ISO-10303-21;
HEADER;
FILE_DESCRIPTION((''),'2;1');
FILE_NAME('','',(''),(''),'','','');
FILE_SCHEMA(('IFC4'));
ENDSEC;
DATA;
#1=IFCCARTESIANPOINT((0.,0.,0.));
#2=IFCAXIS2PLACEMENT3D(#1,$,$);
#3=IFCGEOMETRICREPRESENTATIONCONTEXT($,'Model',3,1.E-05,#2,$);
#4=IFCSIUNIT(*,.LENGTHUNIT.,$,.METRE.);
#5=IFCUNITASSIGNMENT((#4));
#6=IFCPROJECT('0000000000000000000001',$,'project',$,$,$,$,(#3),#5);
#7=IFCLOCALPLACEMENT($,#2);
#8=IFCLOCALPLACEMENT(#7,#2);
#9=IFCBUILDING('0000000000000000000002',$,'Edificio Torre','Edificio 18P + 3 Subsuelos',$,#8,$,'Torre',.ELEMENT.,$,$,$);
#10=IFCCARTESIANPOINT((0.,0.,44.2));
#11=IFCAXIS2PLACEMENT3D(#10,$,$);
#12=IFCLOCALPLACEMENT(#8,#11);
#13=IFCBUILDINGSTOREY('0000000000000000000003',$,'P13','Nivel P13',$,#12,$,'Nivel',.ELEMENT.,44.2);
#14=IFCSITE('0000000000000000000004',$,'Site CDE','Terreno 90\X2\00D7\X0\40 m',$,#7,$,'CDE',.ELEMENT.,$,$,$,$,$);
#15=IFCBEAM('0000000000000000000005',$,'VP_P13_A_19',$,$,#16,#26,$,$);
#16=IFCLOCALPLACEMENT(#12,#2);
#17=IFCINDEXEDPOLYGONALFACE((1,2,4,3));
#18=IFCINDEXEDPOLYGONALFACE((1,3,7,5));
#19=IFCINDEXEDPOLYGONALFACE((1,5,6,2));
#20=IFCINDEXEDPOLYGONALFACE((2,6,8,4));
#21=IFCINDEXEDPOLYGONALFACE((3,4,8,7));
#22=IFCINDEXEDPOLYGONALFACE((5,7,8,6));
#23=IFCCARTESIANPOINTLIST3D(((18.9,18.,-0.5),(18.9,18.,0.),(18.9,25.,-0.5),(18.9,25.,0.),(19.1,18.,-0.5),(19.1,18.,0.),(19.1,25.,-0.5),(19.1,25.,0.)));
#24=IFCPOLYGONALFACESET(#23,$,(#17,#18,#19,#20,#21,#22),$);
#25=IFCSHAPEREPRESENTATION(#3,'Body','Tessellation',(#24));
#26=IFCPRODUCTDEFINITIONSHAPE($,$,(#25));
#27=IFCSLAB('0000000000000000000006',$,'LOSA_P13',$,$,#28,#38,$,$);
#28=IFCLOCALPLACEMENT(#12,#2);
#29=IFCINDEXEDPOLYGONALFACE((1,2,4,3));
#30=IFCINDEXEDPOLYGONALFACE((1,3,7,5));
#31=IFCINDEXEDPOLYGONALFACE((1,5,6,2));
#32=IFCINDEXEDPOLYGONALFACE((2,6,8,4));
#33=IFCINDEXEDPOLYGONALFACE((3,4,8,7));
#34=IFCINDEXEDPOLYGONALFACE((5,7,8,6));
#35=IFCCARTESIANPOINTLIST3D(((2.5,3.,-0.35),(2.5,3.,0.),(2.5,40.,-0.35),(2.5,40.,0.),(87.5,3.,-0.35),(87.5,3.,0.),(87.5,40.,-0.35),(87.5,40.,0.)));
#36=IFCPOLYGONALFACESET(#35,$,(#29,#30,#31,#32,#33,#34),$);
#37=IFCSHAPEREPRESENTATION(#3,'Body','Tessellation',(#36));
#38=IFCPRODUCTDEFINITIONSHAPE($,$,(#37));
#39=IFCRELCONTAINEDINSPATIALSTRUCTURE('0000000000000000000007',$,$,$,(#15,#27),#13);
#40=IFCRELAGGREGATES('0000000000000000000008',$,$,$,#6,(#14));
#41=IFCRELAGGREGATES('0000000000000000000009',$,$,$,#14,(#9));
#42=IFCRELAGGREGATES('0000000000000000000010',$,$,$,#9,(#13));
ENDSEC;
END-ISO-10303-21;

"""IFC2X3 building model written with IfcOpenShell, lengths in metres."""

from ifc_helpers import new_model, si_unit, frame, origin, origin_2d, place, context, project, spatial, rectangle, extrude, element, save


model = new_model("IFC2X3")

# Units and contexts
model_context = context("Model", 3, precision=1e-05, world=origin())
ifc_project = project(units=[si_unit("LENGTHUNIT", "METRE")], contexts=[model_context])

# Site, building, storey
site_placement = place(None, origin())
site = spatial("IfcSite", under=ifc_project, at=site_placement, Name="Site CDE", Description="Terreno 90×40 m", LongName="CDE", CompositionType="ELEMENT")
building_placement = place(site_placement, origin())
building = spatial("IfcBuilding", under=site, at=building_placement, Name="Edificio Torre", Description="Edificio 18P + 3 Subsuelos", LongName="Torre", CompositionType="ELEMENT")
storey_placement = place(building_placement, frame((0.0, 0.0, 44.2)))
storey = spatial("IfcBuildingStorey", under=building, at=storey_placement, Name="P13", Description="Nivel P13", LongName="Nivel", CompositionType="ELEMENT", Elevation=44.2)

# Beam
beam_1_placement = place(storey_placement, frame((19.0, 21.5, -0.5)))
element("IfcBeam", 1, at=beam_1_placement, inside=storey, Name="VP_P13_A_19", context=model_context, shape_type="SweptSolid", body=[
    extrude(rectangle(XDim=0.2, YDim=7.0, at=origin_2d()), origin(), (0.0, 0.0, 1.0), 0.5),
])

# Slab
slab_placement = place(storey_placement, frame((45.0, 21.5, -0.35)))
element("IfcSlab", 2, at=slab_placement, inside=storey, Name="LOSA_P13", context=model_context, shape_type="SweptSolid", body=[
    extrude(rectangle(XDim=85.0, YDim=37.0, at=origin_2d()), origin(), (0.0, 0.0, 1.0), 0.35),
])

save(model, "model.ifc")
